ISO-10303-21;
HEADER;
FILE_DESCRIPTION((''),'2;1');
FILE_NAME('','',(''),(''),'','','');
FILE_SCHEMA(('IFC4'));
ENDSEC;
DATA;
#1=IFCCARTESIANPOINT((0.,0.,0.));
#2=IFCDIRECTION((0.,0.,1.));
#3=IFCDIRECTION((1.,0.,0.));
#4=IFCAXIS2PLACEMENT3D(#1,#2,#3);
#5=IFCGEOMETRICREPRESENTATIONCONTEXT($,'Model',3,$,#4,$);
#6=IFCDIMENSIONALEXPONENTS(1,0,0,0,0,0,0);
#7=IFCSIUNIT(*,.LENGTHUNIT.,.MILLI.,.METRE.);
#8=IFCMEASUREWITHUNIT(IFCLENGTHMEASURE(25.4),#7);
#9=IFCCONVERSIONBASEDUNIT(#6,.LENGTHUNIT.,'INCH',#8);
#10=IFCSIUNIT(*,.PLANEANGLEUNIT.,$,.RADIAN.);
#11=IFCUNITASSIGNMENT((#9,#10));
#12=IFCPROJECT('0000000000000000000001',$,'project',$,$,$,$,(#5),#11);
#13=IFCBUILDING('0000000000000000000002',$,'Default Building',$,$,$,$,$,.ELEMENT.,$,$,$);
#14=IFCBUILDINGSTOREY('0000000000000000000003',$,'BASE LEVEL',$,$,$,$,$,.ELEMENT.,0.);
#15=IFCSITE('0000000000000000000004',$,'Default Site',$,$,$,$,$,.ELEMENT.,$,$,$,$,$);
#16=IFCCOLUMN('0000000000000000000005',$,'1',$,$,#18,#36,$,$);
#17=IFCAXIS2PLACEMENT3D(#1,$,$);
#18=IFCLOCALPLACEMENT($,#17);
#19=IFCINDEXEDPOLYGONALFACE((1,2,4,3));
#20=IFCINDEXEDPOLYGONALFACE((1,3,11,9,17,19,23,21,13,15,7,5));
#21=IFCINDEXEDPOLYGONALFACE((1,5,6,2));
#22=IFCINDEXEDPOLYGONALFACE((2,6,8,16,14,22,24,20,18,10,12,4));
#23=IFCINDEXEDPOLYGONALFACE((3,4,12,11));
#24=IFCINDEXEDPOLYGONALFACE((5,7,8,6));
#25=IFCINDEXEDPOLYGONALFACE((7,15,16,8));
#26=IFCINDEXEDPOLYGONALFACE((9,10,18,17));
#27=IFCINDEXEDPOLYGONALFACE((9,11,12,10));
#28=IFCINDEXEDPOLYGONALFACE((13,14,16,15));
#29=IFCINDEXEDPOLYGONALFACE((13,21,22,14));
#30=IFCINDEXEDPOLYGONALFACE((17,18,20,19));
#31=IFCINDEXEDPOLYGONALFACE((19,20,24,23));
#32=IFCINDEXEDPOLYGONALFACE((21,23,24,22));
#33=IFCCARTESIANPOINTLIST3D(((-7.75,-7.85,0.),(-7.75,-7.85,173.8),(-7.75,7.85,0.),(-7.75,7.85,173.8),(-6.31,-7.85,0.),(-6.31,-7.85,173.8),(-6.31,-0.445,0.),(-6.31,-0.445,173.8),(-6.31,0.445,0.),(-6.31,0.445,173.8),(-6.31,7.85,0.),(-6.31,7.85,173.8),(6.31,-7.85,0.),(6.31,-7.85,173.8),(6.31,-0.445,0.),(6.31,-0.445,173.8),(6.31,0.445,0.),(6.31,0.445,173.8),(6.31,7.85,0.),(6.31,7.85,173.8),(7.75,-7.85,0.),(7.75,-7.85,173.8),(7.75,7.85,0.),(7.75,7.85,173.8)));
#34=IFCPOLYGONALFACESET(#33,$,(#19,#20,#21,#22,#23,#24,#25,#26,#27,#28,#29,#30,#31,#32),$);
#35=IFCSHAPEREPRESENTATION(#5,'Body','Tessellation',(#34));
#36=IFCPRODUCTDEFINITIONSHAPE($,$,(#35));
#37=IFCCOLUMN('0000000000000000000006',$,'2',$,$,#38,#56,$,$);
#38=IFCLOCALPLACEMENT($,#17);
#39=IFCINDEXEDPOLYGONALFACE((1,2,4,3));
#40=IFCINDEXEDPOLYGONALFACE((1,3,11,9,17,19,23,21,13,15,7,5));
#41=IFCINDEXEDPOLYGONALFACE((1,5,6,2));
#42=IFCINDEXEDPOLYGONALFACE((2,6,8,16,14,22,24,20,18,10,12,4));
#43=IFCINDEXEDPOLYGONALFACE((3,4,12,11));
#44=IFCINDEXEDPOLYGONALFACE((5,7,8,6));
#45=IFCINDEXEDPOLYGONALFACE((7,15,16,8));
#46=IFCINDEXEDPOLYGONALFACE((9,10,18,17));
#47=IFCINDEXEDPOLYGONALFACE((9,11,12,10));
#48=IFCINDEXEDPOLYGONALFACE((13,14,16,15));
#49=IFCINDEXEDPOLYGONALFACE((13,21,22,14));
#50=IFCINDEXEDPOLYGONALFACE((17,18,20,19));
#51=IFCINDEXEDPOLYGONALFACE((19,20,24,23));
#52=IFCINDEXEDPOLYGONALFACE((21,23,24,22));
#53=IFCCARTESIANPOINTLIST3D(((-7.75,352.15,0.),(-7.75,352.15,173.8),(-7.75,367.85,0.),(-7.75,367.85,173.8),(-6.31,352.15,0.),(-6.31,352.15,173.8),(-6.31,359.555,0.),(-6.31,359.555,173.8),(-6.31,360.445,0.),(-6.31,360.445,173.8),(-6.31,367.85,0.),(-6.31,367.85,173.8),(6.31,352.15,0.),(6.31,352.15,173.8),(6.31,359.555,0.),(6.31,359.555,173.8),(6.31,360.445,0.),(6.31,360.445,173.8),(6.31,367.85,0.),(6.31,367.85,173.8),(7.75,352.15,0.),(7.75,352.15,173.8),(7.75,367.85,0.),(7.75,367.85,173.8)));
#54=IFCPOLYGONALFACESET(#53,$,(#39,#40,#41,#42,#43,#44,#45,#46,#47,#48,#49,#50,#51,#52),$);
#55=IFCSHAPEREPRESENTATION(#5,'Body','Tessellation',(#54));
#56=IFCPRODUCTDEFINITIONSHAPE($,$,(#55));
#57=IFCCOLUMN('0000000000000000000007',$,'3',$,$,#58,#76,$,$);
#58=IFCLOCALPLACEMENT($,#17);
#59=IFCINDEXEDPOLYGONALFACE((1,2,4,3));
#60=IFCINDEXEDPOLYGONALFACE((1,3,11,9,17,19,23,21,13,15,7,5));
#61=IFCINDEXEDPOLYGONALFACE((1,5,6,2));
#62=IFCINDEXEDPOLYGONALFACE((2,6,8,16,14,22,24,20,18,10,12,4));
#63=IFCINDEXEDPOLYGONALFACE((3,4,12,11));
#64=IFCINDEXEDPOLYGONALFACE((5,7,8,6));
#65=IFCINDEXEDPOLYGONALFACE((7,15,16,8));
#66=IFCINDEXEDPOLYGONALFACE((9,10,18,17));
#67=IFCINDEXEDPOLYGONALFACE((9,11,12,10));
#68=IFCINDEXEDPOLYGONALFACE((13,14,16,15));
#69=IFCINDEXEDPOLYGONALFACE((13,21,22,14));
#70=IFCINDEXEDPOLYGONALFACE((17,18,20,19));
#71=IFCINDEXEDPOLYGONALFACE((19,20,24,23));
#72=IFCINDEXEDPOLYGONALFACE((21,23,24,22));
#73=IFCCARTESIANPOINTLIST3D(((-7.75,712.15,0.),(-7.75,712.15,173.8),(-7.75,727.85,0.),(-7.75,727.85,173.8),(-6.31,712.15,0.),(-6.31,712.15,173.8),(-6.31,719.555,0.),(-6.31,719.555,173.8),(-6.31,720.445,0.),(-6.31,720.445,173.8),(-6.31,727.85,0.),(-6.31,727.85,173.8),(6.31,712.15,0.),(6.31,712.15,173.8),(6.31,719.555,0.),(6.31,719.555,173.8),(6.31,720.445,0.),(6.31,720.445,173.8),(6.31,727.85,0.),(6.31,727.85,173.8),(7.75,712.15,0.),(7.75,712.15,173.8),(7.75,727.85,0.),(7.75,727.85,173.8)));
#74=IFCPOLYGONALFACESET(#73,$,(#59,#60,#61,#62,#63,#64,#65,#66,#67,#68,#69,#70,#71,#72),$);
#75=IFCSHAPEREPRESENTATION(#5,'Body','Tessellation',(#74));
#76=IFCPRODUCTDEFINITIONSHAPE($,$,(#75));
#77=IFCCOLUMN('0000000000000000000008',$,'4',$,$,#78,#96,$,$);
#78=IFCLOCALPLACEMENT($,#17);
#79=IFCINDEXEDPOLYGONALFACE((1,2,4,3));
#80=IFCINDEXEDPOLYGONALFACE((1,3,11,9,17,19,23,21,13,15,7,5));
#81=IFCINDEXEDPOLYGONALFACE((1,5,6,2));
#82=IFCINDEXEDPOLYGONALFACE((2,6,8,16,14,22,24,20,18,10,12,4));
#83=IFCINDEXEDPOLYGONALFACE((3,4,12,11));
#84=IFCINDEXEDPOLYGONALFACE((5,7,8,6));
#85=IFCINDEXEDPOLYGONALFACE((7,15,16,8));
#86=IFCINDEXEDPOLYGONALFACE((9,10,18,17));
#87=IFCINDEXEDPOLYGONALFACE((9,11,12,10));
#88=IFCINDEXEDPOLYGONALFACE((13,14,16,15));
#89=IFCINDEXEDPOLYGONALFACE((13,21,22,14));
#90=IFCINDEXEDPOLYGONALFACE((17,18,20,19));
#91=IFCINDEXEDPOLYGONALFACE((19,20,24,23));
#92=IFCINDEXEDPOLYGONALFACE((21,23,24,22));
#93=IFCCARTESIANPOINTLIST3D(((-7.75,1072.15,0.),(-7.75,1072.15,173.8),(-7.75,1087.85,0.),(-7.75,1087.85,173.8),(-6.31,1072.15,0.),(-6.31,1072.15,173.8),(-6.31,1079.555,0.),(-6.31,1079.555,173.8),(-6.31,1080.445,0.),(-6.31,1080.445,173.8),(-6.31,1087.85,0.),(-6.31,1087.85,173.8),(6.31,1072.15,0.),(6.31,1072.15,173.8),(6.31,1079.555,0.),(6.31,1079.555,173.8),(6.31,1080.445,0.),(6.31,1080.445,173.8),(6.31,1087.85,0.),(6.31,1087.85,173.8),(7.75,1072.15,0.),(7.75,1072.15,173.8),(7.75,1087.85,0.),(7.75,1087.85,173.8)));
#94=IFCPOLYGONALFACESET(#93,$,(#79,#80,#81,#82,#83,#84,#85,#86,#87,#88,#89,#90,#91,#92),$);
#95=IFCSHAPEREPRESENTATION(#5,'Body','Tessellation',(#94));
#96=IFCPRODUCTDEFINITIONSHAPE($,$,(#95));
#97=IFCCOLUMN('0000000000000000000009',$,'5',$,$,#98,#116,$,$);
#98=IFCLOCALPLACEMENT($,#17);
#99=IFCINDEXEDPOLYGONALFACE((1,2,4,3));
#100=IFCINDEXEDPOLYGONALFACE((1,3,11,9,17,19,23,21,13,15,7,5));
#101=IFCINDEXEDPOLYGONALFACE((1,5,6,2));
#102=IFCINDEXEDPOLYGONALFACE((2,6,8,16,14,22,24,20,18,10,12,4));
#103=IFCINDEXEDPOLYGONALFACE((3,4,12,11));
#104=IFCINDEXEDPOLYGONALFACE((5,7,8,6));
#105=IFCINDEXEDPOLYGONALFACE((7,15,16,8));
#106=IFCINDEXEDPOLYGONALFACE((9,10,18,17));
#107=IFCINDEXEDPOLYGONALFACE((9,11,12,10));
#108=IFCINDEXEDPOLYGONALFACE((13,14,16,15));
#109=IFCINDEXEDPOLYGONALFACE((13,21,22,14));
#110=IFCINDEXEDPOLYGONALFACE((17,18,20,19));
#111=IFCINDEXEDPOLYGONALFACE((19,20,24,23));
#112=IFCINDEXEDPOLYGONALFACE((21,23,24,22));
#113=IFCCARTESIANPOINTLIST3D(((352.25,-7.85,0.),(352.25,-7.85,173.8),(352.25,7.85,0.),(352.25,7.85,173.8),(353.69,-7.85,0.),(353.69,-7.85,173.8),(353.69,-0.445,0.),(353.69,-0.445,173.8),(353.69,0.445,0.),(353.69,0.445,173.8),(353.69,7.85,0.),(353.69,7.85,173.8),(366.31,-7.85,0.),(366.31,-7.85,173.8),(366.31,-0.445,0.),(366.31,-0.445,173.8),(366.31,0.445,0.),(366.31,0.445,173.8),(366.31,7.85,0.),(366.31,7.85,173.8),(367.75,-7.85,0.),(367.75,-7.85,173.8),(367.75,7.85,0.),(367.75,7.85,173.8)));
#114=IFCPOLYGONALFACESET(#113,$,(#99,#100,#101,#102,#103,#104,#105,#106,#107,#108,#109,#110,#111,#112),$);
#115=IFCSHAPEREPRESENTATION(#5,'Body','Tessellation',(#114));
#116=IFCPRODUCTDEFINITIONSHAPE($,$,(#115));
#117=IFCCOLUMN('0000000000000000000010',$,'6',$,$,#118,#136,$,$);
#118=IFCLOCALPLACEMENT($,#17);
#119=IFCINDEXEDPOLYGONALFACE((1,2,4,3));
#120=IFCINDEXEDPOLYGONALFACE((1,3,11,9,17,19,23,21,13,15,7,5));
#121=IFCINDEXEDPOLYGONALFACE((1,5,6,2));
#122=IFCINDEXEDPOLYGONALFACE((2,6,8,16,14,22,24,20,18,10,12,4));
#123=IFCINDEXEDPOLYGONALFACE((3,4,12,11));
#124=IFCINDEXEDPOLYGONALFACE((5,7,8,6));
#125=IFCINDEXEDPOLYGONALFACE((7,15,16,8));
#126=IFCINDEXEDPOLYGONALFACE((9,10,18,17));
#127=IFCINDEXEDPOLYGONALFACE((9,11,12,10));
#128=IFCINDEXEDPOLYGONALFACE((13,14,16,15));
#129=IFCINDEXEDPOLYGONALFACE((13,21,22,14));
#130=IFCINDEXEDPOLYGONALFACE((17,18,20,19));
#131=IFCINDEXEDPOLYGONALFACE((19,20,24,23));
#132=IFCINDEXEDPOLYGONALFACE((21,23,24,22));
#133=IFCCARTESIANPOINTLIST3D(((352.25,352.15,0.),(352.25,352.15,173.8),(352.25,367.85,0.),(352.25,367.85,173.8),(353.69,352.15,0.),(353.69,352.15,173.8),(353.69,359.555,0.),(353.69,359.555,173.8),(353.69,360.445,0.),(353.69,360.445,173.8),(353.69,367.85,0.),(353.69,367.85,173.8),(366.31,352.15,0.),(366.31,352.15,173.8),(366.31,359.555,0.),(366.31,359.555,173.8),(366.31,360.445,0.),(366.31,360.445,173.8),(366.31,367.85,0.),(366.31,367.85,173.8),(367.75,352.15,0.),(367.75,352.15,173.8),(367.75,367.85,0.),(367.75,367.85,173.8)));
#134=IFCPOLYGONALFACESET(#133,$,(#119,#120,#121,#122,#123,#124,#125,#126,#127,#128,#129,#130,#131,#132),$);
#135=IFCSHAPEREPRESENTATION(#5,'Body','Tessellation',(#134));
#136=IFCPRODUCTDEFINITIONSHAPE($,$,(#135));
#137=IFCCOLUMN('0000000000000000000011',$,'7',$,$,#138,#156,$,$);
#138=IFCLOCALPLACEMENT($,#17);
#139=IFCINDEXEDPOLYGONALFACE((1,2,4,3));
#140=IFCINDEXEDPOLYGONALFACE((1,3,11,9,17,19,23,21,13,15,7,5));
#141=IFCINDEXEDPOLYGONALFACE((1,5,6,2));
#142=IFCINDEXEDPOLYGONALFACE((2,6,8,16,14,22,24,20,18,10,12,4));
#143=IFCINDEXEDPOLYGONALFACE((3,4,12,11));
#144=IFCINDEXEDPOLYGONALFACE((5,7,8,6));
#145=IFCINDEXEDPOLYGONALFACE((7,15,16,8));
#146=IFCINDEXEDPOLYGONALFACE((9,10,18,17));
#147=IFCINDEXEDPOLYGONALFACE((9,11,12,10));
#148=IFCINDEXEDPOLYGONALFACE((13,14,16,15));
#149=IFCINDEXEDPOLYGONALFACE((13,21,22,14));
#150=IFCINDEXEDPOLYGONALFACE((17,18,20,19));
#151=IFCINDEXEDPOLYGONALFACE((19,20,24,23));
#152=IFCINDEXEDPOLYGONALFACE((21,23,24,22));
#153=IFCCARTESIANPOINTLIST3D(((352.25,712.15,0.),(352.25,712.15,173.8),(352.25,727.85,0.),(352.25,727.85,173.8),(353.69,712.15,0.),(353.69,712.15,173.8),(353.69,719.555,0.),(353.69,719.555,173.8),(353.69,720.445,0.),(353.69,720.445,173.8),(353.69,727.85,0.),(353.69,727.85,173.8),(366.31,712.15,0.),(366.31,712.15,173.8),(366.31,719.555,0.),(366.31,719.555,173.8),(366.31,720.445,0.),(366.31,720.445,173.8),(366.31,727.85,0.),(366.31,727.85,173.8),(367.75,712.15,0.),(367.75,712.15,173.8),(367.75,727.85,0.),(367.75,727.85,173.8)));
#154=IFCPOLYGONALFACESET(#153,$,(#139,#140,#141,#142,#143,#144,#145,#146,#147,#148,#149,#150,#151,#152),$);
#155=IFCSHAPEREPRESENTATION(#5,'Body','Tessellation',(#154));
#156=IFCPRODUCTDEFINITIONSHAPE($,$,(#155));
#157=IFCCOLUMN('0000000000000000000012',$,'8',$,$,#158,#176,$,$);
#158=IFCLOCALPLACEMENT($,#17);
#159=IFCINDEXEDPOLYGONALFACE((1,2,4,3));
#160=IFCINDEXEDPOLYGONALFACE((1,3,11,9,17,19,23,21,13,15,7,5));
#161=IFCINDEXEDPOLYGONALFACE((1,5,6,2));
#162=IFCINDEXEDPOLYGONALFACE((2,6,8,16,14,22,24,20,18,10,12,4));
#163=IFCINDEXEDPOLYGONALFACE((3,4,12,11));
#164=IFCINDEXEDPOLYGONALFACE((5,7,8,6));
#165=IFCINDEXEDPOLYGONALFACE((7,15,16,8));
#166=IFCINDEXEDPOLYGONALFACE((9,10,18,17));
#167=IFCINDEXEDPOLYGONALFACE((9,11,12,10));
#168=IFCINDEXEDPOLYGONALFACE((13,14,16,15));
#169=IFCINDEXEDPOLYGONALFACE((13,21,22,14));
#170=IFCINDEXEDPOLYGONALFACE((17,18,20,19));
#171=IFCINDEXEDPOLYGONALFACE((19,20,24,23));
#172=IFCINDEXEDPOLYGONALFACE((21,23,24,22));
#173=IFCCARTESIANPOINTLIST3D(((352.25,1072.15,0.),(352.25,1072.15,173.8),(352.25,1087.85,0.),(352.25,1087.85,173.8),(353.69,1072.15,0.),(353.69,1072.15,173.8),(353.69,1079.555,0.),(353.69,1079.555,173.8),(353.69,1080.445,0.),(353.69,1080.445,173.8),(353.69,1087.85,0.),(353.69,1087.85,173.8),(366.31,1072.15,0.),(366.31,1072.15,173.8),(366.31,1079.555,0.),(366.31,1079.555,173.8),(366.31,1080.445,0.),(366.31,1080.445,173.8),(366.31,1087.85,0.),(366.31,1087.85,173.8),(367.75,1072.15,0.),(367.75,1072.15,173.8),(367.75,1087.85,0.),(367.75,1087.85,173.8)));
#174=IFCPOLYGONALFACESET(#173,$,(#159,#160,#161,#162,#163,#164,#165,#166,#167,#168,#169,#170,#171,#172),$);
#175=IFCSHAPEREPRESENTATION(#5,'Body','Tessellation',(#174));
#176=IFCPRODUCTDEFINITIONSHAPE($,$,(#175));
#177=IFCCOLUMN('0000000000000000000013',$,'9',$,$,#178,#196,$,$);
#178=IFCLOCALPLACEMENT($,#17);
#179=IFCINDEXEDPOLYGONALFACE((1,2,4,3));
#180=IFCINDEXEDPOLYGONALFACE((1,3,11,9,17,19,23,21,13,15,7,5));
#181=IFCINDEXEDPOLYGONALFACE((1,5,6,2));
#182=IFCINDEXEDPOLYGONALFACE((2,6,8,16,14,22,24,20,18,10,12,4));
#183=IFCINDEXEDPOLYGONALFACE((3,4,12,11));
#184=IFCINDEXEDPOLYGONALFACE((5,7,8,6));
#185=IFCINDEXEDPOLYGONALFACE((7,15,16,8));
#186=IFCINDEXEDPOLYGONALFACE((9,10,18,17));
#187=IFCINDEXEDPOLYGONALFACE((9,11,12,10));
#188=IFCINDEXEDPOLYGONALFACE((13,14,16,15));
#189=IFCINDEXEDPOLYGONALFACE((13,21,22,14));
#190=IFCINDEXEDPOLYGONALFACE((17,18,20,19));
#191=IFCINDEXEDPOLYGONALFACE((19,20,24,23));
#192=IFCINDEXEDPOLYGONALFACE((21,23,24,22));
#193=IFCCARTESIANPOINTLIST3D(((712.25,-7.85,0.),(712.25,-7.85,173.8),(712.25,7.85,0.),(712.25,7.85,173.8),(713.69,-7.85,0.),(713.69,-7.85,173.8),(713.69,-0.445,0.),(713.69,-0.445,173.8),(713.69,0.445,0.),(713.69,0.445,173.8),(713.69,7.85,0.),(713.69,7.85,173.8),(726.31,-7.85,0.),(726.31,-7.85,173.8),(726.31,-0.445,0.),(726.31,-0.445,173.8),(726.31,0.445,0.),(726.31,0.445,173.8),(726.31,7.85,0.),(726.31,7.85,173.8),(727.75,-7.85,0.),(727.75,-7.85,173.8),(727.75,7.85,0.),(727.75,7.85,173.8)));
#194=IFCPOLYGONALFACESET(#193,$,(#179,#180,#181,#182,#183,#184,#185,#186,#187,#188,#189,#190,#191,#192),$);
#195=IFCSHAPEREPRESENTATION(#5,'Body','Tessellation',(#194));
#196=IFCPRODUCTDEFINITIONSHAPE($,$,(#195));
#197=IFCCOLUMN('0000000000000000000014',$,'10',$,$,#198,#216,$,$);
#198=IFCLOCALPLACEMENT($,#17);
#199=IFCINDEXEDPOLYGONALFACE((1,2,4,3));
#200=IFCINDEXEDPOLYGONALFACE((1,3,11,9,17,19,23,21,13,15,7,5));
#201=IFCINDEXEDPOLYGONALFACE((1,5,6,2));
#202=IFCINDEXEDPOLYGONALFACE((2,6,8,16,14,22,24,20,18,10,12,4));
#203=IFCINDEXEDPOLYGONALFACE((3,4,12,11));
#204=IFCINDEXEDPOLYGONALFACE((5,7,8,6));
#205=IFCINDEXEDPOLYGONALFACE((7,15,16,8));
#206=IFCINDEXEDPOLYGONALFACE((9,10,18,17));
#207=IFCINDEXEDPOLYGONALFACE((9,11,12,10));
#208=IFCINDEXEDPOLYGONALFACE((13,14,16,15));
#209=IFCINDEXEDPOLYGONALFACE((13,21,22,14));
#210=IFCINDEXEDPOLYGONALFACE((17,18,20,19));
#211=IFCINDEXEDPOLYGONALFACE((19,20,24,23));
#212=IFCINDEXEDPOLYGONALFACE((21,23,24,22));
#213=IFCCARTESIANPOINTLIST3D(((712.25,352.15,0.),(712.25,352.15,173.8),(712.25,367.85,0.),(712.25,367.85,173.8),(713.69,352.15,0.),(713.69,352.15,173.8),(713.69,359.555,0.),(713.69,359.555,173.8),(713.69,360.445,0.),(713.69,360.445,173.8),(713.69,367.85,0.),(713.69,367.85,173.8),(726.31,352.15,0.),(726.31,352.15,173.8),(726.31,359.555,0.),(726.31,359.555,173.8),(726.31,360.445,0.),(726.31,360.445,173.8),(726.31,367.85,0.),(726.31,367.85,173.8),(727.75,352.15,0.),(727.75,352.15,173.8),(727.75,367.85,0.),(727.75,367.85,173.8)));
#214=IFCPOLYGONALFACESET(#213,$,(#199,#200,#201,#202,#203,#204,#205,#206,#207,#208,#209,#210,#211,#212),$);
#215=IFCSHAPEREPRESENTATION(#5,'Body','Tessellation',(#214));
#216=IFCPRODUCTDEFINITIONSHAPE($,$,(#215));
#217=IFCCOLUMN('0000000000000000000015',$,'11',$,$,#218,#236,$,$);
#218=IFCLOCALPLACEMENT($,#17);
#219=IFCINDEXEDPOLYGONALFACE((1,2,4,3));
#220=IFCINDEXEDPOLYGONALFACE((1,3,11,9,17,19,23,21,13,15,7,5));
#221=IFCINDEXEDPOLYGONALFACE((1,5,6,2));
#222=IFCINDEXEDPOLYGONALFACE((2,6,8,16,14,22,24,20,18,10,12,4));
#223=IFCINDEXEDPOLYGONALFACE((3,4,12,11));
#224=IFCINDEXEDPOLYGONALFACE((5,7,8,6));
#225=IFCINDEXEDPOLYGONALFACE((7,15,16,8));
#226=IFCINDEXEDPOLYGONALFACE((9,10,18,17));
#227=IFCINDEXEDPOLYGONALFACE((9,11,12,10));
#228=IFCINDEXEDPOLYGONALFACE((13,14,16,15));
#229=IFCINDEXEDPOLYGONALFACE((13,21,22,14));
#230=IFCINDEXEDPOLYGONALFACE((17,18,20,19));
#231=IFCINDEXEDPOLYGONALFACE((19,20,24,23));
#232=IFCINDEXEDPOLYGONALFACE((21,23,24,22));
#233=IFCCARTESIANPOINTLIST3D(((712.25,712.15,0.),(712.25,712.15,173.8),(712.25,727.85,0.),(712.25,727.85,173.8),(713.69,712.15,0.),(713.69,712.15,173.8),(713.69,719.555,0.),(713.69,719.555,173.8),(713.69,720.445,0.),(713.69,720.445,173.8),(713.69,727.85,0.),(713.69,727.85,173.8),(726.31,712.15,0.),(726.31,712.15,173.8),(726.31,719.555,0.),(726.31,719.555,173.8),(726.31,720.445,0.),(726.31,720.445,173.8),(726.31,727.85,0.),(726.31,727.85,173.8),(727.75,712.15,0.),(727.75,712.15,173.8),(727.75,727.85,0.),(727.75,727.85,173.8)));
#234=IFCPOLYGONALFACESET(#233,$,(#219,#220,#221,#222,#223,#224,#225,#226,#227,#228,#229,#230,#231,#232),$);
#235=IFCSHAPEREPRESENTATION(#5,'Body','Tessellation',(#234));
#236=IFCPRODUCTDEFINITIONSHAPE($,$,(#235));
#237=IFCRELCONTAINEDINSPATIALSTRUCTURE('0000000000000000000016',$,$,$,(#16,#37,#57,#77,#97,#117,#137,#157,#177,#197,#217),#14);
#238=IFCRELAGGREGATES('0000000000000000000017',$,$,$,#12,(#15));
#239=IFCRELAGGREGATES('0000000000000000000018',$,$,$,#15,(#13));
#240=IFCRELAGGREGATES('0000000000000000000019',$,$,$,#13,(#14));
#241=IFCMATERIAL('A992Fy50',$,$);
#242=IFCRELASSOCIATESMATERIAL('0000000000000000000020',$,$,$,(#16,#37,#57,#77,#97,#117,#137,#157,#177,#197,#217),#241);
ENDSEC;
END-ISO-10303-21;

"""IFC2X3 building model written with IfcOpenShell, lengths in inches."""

from ifc_helpers import new_model, entity, si_unit, converted_unit, frame, origin_with_axes, origin_2d_with_axis, place, context, project, spatial, i_section, extrude, material, element, save


model = new_model("IFC2X3")

# Units and contexts
model_context = context("Model", 3, world=origin_with_axes())
ifc_project = project(units=[converted_unit("LENGTHUNIT", "INCH", entity("IfcLengthMeasure", 25.4), si_unit("LENGTHUNIT", "METRE", prefix="MILLI"), dimensions=[1, 0, 0, 0, 0, 0, 0]), si_unit("PLANEANGLEUNIT", "RADIAN")], contexts=[model_context])

# Site, building, storey
site = spatial("IfcSite", under=ifc_project, Name="Default Site", CompositionType="ELEMENT")
building = spatial("IfcBuilding", under=site, Name="Default Building", CompositionType="ELEMENT")
storey = spatial("IfcBuildingStorey", under=building, Name="BASE LEVEL", CompositionType="ELEMENT", Elevation=0.0)

# Columns
ifc_material = material(Name="A992Fy50")
for number, where, z_axis, x_axis, name in (
    (1, (0.0, 0.0, 0.0), (0.0, 0.0, 1.0), (0.0, -1.0, 0.0), "1"),
    (2, (0.0, 360.0, 0.0), (0.0, 0.0, 1.0), (0.0, -1.0, 0.0), "2"),
    (3, (0.0, 720.0, 0.0), (0.0, 0.0, 1.0), (0.0, -1.0, 0.0), "3"),
    (4, (0.0, 1080.0, 0.0), (0.0, 0.0, 1.0), (0.0, -1.0, 0.0), "4"),
    (5, (360.0, 0.0, 0.0), (0.0, 0.0, 1.0), (0.0, -1.0, 0.0), "5"),
    (6, (360.0, 360.0, 0.0), (0.0, 0.0, 1.0), (0.0, -1.0, 0.0), "6"),
    (7, (360.0, 720.0, 0.0), (0.0, 0.0, 1.0), (0.0, -1.0, 0.0), "7"),
    (8, (360.0, 1080.0, 0.0), (0.0, 0.0, 1.0), (0.0, -1.0, 0.0), "8"),
    (9, (720.0, 0.0, 0.0), (0.0, 0.0, 1.0), (0.0, -1.0, 0.0), "9"),
    (10, (720.0, 360.0, 0.0), (0.0, 0.0, 1.0), (0.0, -1.0, 0.0), "10"),
    (11, (720.0, 720.0, 0.0), (0.0, 0.0, 1.0), (0.0, -1.0, 0.0), "11"),
):
    element("IfcColumn", number, at=place(None, frame(where, z_axis=z_axis, x_axis=x_axis)), inside=storey, material=ifc_material, Name=name, context=model_context, shape_type="SweptSolid", body=[
        extrude(i_section(OverallWidth=15.7, OverallDepth=15.5, WebThickness=0.89, FlangeThickness=1.44, at=origin_2d_with_axis()), origin_with_axes(), (0.0, 0.0, 1.0), 173.8),
    ])

save(model, "model.ifc")
